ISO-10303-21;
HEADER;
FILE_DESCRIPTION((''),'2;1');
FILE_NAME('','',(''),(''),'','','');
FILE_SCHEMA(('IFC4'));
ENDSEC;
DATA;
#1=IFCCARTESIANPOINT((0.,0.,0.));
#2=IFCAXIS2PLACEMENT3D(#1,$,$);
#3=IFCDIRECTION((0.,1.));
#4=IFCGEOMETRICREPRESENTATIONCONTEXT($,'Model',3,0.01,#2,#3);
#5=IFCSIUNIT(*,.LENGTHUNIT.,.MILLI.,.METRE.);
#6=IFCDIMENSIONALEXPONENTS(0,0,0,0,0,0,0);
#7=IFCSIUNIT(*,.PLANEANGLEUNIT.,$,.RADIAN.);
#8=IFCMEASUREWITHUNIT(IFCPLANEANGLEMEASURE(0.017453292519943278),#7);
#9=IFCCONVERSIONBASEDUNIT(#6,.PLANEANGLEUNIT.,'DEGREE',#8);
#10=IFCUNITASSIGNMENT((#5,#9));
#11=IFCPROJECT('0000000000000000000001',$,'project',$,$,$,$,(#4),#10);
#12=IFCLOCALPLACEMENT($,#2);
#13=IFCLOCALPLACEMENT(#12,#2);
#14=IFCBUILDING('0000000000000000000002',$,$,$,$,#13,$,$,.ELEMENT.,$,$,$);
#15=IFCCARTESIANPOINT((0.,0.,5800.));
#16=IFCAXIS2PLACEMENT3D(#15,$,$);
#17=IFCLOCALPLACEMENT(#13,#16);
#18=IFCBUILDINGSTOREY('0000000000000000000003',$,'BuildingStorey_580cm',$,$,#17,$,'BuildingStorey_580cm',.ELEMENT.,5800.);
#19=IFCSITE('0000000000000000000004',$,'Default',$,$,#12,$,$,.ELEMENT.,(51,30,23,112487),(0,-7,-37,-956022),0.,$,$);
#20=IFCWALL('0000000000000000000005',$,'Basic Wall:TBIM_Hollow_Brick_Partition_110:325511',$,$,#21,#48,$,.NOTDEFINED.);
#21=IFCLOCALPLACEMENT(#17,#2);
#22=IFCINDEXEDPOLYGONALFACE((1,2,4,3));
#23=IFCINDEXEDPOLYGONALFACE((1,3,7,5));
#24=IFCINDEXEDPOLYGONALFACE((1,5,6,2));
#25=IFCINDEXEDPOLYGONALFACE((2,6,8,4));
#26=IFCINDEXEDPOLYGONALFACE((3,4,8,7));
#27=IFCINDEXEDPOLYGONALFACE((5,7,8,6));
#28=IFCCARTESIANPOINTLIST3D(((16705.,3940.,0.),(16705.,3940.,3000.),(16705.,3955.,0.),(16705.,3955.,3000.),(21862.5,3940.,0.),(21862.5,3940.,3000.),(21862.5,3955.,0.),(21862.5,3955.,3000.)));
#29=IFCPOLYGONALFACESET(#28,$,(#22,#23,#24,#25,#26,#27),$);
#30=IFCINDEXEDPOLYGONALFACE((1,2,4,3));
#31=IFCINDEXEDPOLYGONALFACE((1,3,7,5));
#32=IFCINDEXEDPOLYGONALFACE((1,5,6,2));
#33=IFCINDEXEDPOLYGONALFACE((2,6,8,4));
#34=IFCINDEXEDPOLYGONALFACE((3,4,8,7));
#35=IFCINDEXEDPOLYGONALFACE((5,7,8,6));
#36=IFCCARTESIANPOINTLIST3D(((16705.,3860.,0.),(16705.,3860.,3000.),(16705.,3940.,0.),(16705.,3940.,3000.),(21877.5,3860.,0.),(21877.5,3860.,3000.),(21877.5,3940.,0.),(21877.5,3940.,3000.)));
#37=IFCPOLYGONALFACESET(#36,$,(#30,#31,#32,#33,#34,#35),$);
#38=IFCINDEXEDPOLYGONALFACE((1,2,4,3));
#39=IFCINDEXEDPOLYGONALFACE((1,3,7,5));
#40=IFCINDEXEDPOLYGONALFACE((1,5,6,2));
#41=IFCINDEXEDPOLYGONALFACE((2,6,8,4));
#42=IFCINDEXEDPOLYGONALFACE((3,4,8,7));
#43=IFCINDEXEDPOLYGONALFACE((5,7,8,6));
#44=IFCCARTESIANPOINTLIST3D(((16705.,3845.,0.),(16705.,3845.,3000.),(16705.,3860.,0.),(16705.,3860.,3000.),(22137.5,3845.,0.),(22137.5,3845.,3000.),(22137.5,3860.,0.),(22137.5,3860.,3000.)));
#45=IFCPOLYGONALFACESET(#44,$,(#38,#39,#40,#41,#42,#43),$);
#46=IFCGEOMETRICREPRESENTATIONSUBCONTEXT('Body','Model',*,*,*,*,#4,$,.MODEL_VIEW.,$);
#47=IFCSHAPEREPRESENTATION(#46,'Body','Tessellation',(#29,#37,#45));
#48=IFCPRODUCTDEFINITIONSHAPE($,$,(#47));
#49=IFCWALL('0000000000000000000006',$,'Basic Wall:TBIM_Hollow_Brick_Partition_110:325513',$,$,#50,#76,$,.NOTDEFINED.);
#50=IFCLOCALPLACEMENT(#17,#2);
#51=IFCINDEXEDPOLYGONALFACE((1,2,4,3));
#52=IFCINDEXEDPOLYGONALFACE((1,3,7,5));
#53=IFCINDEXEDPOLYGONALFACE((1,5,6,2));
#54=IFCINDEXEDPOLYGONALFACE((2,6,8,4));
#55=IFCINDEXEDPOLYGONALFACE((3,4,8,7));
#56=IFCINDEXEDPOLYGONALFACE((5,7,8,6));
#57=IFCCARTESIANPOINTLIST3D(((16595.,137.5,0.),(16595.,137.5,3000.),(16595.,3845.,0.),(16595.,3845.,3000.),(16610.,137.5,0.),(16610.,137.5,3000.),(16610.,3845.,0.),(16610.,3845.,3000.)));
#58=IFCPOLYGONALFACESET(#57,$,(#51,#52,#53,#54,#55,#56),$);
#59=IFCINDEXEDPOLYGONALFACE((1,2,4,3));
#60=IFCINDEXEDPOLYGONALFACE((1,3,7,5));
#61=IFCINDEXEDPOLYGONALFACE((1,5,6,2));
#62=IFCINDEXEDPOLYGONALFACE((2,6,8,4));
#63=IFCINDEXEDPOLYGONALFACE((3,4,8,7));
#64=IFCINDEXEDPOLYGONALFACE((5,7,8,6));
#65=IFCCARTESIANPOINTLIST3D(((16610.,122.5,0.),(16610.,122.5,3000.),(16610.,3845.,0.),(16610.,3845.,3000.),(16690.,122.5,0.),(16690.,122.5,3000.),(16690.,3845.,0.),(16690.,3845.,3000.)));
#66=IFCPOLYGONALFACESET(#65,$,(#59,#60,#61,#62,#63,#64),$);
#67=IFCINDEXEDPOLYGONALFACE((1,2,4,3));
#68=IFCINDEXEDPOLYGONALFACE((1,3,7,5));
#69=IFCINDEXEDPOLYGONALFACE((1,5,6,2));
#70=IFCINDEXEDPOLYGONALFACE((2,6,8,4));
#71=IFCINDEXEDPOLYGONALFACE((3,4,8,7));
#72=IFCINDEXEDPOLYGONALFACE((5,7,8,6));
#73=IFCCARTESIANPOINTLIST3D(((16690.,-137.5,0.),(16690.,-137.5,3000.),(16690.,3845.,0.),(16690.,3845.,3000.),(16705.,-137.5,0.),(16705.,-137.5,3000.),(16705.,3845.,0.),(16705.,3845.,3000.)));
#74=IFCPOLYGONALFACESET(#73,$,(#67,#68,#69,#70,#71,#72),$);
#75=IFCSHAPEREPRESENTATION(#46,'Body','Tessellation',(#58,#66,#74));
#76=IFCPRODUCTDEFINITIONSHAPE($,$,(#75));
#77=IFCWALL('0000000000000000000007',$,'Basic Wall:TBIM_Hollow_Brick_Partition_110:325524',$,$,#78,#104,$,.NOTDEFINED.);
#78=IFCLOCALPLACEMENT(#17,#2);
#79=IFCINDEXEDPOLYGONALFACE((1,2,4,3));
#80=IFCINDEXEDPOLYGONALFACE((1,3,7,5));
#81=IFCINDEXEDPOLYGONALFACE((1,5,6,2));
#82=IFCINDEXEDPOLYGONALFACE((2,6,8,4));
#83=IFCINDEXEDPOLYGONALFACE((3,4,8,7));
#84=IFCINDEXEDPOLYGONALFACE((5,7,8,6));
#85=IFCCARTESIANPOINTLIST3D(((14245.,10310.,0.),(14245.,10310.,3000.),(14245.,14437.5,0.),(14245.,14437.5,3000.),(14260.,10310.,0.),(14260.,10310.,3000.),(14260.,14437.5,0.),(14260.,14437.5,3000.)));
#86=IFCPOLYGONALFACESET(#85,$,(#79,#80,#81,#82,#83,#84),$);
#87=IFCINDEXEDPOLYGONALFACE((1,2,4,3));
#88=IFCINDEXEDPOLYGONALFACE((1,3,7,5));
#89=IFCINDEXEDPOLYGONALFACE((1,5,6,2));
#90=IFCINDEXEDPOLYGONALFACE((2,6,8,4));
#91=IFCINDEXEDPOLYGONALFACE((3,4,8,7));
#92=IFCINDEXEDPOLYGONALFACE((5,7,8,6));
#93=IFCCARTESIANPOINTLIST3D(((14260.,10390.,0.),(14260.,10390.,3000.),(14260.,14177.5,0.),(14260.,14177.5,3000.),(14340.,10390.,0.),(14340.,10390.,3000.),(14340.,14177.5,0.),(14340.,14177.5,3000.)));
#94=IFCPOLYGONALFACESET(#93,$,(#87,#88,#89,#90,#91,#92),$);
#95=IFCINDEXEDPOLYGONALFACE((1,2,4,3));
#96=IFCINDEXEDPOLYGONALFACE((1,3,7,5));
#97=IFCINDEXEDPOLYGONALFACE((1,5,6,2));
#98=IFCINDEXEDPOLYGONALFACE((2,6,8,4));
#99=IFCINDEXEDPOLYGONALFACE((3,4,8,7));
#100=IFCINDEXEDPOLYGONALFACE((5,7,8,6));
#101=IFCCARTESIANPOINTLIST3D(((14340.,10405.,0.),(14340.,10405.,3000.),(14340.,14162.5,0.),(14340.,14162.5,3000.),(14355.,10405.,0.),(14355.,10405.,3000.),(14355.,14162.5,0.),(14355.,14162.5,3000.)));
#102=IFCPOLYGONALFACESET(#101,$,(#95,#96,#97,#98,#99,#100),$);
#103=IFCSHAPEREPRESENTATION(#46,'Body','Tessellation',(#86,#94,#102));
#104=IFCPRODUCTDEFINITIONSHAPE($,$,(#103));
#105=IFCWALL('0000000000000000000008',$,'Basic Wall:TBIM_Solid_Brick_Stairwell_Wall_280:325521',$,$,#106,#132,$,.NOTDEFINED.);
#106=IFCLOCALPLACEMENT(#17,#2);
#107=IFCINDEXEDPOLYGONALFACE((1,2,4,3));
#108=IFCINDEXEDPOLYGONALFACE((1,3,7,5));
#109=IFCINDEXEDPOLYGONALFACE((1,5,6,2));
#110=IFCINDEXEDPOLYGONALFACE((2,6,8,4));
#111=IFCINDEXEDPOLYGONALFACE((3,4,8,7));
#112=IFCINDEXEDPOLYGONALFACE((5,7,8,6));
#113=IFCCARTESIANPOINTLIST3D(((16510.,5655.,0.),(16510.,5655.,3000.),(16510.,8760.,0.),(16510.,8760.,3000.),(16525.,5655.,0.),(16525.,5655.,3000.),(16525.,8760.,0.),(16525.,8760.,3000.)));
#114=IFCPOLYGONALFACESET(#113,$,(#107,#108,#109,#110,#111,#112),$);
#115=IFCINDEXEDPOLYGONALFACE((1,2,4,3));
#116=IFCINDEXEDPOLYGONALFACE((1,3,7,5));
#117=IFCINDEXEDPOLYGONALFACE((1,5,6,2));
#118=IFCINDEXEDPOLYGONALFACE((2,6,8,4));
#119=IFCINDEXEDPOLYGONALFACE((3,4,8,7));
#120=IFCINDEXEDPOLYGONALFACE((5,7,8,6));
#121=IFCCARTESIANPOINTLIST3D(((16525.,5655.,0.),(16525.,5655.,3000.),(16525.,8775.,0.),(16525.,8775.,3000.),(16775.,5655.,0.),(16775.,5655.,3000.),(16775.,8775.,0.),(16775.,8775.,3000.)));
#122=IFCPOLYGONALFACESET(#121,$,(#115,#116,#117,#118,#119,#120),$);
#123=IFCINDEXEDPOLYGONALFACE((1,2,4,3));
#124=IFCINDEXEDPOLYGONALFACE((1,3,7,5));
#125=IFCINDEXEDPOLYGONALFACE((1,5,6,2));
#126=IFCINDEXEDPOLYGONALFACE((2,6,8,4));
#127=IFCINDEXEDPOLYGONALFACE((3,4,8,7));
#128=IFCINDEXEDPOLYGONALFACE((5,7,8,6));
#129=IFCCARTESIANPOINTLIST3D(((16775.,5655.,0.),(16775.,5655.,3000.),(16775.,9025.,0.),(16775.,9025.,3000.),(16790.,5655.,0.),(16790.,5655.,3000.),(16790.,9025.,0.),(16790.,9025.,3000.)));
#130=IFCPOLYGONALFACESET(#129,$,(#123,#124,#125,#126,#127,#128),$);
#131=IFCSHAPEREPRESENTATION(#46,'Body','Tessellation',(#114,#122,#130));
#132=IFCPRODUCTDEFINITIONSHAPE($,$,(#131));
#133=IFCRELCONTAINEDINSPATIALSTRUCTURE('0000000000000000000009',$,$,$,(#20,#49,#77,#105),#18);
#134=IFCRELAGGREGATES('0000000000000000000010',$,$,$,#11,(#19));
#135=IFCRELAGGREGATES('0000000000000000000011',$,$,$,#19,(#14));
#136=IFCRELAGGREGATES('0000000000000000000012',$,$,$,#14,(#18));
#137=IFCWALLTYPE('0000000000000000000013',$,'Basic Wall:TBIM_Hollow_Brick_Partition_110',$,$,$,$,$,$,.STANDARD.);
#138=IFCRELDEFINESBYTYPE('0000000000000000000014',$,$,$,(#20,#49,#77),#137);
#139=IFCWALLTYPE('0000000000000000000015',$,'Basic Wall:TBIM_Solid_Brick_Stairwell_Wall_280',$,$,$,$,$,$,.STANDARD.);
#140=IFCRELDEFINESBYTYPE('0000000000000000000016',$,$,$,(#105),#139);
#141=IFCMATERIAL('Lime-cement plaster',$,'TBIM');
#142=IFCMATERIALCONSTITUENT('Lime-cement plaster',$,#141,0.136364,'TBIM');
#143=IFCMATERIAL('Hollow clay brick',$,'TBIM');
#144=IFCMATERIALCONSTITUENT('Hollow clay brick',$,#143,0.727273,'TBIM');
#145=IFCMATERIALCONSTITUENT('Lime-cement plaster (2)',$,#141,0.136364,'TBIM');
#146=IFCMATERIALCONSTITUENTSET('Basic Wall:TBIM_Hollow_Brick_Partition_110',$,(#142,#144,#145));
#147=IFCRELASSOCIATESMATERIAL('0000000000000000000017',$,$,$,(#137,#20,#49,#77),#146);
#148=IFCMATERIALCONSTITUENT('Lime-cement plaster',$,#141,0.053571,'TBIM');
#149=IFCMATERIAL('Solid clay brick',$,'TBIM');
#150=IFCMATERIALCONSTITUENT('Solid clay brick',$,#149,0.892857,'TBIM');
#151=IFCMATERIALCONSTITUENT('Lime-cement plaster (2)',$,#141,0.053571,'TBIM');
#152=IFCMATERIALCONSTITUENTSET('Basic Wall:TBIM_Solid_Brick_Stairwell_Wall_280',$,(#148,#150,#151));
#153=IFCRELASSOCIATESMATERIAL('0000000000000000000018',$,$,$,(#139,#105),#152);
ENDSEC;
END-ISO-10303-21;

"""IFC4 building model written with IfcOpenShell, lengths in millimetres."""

from ifc_helpers import new_model, entity, si_unit, converted_unit, direction, frame, origin, place, context, subcontext, project, spatial, indexed_curve, outline, extrude, material, constituent, constituent_set, type_object, element, save


model = new_model("IFC4")

# Units and contexts
model_context = context("Model", 3, precision=0.01, world=origin(), true_north=direction((0.0, 1.0)))
body_context = subcontext(model_context, "Body", "Model", "MODEL_VIEW")
ifc_project = project(units=[si_unit("LENGTHUNIT", "METRE", prefix="MILLI"), converted_unit("PLANEANGLEUNIT", "DEGREE", entity("IfcPlaneAngleMeasure", 0.017453292519943278), si_unit("PLANEANGLEUNIT", "RADIAN"), dimensions=[0, 0, 0, 0, 0, 0, 0])], contexts=[model_context])

# Site, building, storey
site_placement = place(None, origin())
site = spatial("IfcSite", under=ifc_project, at=site_placement, Name="Default", CompositionType="ELEMENT", RefLatitude=(51, 30, 23, 112487), RefLongitude=(0, -7, -37, -956022), RefElevation=0.0)
building_placement = place(site_placement, origin())
building = spatial("IfcBuilding", under=site, at=building_placement, CompositionType="ELEMENT")
storey_placement = place(building_placement, frame((0.0, 0.0, 5800.0)))
storey = spatial("IfcBuildingStorey", under=building, at=storey_placement, Name="BuildingStorey_580cm", LongName="BuildingStorey_580cm", CompositionType="ELEMENT", Elevation=5800.0)

# Shared definitions
ifc_material_1 = material(Name="Hollow clay brick", Category="TBIM")
ifc_material_2 = material(Name="Lime-cement plaster", Category="TBIM")
ifc_constituent_1 = constituent(ifc_material_2, Name="Lime-cement plaster", Category="TBIM", fraction=0.136364)
ifc_constituent_2 = constituent(ifc_material_1, Name="Hollow clay brick", Category="TBIM", fraction=0.727273)
ifc_constituent_3 = constituent(ifc_material_2, Name="Lime-cement plaster (2)", Category="TBIM", fraction=0.136364)
ifc_constituent_set_1 = constituent_set(constituents=[ifc_constituent_1, ifc_constituent_2, ifc_constituent_3], Name="Basic Wall:TBIM_Hollow_Brick_Partition_110")
wall_type_1 = type_object("IfcWallType", Name="Basic Wall:TBIM_Hollow_Brick_Partition_110", PredefinedType="STANDARD", material=ifc_constituent_set_1)

# Walls
wall_1_placement = place(storey_placement, frame((16705.0, 3900.0, 0.0)))
element("IfcWall", 1, at=wall_1_placement, inside=storey, type_object=wall_type_1, material=ifc_constituent_set_1, Name="Basic Wall:TBIM_Hollow_Brick_Partition_110:325511", PredefinedType="NOTDEFINED", context=body_context, shape_type="SweptSolid", body=[
    extrude(outline(indexed_curve([(-7.5, -2578.8), (7.5, -2578.8), (7.5, 2578.8), (-7.5, 2578.8), (-7.5, -2578.8)], self_intersect=False)), frame((2578.8, 47.5, 0.0), z_axis=(0.0, 0.0, 1.0), x_axis=(0.0, -1.0, 0.0)), (0.0, 0.0, 1.0), 3000.0),
    extrude(outline(indexed_curve([(-2586.3, -40.0), (2586.3, -40.0), (2586.3, 40.0), (-2586.3, 40.0), (-2586.3, -40.0)], self_intersect=False)), frame((2586.3, 0.0, 0.0)), (0.0, 0.0, 1.0), 3000.0),
    extrude(outline(indexed_curve([(-7.5, -2716.3), (7.5, -2716.3), (7.5, 2716.3), (-7.5, 2716.3), (-7.5, -2716.3)], self_intersect=False)), frame((2716.3, -47.5, 0.0), z_axis=(0.0, 0.0, 1.0), x_axis=(0.0, 1.0, 0.0)), (0.0, 0.0, 1.0), 3000.0),
])
wall_2_placement = place(storey_placement, frame((16650.0, 137.5, 0.0), z_axis=(0.0, 0.0, 1.0), x_axis=(0.0, 1.0, 0.0)))
element("IfcWall", 2, at=wall_2_placement, inside=storey, type_object=wall_type_1, material=ifc_constituent_set_1, Name="Basic Wall:TBIM_Hollow_Brick_Partition_110:325513", PredefinedType="NOTDEFINED", context=body_context, shape_type="SweptSolid", body=[
    extrude(outline(indexed_curve([(-7.5, -1853.8), (7.5, -1853.8), (7.5, 1853.8), (-7.5, 1853.8), (-7.5, -1853.8)], self_intersect=False)), frame((1853.8, 47.5, 0.0), z_axis=(0.0, 0.0, 1.0), x_axis=(0.0, -1.0, 0.0)), (0.0, 0.0, 1.0), 3000.0),
    extrude(outline(indexed_curve([(-1861.3, -40.0), (1861.3, -40.0), (1861.3, 40.0), (-1861.3, 40.0), (-1861.3, -40.0)], self_intersect=False)), frame((1846.3, 0.0, 0.0)), (0.0, 0.0, 1.0), 3000.0),
    extrude(outline(indexed_curve([(-7.5, -1991.3), (7.5, -1991.3), (7.5, 1991.3), (-7.5, 1991.3), (-7.5, -1991.3)], self_intersect=False)), frame((1716.3, -47.5, 0.0), z_axis=(0.0, 0.0, 1.0), x_axis=(0.0, 1.0, 0.0)), (0.0, 0.0, 1.0), 3000.0),
])

# Wall
wall_3_placement = place(storey_placement, frame((14300.0, 10405.0, 0.0), z_axis=(0.0, 0.0, 1.0), x_axis=(0.0, 1.0, 0.0)))
element("IfcWall", 3, at=wall_3_placement, inside=storey, type_object=wall_type_1, material=ifc_constituent_set_1, Name="Basic Wall:TBIM_Hollow_Brick_Partition_110:325524", PredefinedType="NOTDEFINED", context=body_context, shape_type="SweptSolid", body=[
    extrude(outline(indexed_curve([(-7.5, -2063.8), (7.5, -2063.8), (7.5, 2063.7), (-7.5, 2063.7), (-7.5, -2063.8)], self_intersect=False)), frame((1968.8, 47.5, 0.0), z_axis=(0.0, 0.0, 1.0), x_axis=(0.0, -1.0, 0.0)), (0.0, 0.0, 1.0), 3000.0),
    extrude(outline(indexed_curve([(-1893.8, -40.0), (1893.8, -40.0), (1893.8, 40.0), (-1893.8, 40.0), (-1893.8, -40.0)], self_intersect=False)), frame((1878.7, 0.0, 0.0)), (0.0, 0.0, 1.0), 3000.0),
    extrude(outline(indexed_curve([(-7.5, -1878.7), (7.5, -1878.7), (7.5, 1878.7), (-7.5, 1878.7), (-7.5, -1878.7)], self_intersect=False)), frame((1878.7, -47.5, 0.0), z_axis=(0.0, 0.0, 1.0), x_axis=(0.0, 1.0, 0.0)), (0.0, 0.0, 1.0), 3000.0),
])

# Wall
ifc_constituent_4 = constituent(ifc_material_2, Name="Lime-cement plaster", Category="TBIM", fraction=0.053571)
ifc_material_3 = material(Name="Solid clay brick", Category="TBIM")
ifc_constituent_5 = constituent(ifc_material_3, Name="Solid clay brick", Category="TBIM", fraction=0.892857)
ifc_constituent_6 = constituent(ifc_material_2, Name="Lime-cement plaster (2)", Category="TBIM", fraction=0.053571)
ifc_constituent_set_2 = constituent_set(constituents=[ifc_constituent_4, ifc_constituent_5, ifc_constituent_6], Name="Basic Wall:TBIM_Solid_Brick_Stairwell_Wall_280")
wall_type_2 = type_object("IfcWallType", Name="Basic Wall:TBIM_Solid_Brick_Stairwell_Wall_280", PredefinedType="STANDARD", material=ifc_constituent_set_2)
wall_4_placement = place(storey_placement, frame((16650.0, 5655.0, 0.0), z_axis=(0.0, 0.0, 1.0), x_axis=(0.0, 1.0, 0.0)))
element("IfcWall", 4, at=wall_4_placement, inside=storey, type_object=wall_type_2, material=ifc_constituent_set_2, Name="Basic Wall:TBIM_Solid_Brick_Stairwell_Wall_280:325521", PredefinedType="NOTDEFINED", context=body_context, shape_type="SweptSolid", body=[
    extrude(outline(indexed_curve([(-7.5, -1552.5), (7.5, -1552.5), (7.5, 1552.5), (-7.5, 1552.5), (-7.5, -1552.5)], self_intersect=False)), frame((1552.5, 132.5, 0.0), z_axis=(0.0, 0.0, 1.0), x_axis=(0.0, -1.0, 0.0)), (0.0, 0.0, 1.0), 3000.0),
    extrude(outline(indexed_curve([(-1560.0, -125.0), (1560.0, -125.0), (1560.0, 125.0), (-1560.0, 125.0), (-1560.0, -125.0)], self_intersect=False)), frame((1560.0, 0.0, 0.0)), (0.0, 0.0, 1.0), 3000.0),
    extrude(outline(indexed_curve([(-7.5, -1685.0), (7.5, -1685.0), (7.5, 1685.0), (-7.5, 1685.0), (-7.5, -1685.0)], self_intersect=False)), frame((1685.0, -132.5, 0.0), z_axis=(0.0, 0.0, 1.0), x_axis=(0.0, 1.0, 0.0)), (0.0, 0.0, 1.0), 3000.0),
])

save(model, "model.ifc")
